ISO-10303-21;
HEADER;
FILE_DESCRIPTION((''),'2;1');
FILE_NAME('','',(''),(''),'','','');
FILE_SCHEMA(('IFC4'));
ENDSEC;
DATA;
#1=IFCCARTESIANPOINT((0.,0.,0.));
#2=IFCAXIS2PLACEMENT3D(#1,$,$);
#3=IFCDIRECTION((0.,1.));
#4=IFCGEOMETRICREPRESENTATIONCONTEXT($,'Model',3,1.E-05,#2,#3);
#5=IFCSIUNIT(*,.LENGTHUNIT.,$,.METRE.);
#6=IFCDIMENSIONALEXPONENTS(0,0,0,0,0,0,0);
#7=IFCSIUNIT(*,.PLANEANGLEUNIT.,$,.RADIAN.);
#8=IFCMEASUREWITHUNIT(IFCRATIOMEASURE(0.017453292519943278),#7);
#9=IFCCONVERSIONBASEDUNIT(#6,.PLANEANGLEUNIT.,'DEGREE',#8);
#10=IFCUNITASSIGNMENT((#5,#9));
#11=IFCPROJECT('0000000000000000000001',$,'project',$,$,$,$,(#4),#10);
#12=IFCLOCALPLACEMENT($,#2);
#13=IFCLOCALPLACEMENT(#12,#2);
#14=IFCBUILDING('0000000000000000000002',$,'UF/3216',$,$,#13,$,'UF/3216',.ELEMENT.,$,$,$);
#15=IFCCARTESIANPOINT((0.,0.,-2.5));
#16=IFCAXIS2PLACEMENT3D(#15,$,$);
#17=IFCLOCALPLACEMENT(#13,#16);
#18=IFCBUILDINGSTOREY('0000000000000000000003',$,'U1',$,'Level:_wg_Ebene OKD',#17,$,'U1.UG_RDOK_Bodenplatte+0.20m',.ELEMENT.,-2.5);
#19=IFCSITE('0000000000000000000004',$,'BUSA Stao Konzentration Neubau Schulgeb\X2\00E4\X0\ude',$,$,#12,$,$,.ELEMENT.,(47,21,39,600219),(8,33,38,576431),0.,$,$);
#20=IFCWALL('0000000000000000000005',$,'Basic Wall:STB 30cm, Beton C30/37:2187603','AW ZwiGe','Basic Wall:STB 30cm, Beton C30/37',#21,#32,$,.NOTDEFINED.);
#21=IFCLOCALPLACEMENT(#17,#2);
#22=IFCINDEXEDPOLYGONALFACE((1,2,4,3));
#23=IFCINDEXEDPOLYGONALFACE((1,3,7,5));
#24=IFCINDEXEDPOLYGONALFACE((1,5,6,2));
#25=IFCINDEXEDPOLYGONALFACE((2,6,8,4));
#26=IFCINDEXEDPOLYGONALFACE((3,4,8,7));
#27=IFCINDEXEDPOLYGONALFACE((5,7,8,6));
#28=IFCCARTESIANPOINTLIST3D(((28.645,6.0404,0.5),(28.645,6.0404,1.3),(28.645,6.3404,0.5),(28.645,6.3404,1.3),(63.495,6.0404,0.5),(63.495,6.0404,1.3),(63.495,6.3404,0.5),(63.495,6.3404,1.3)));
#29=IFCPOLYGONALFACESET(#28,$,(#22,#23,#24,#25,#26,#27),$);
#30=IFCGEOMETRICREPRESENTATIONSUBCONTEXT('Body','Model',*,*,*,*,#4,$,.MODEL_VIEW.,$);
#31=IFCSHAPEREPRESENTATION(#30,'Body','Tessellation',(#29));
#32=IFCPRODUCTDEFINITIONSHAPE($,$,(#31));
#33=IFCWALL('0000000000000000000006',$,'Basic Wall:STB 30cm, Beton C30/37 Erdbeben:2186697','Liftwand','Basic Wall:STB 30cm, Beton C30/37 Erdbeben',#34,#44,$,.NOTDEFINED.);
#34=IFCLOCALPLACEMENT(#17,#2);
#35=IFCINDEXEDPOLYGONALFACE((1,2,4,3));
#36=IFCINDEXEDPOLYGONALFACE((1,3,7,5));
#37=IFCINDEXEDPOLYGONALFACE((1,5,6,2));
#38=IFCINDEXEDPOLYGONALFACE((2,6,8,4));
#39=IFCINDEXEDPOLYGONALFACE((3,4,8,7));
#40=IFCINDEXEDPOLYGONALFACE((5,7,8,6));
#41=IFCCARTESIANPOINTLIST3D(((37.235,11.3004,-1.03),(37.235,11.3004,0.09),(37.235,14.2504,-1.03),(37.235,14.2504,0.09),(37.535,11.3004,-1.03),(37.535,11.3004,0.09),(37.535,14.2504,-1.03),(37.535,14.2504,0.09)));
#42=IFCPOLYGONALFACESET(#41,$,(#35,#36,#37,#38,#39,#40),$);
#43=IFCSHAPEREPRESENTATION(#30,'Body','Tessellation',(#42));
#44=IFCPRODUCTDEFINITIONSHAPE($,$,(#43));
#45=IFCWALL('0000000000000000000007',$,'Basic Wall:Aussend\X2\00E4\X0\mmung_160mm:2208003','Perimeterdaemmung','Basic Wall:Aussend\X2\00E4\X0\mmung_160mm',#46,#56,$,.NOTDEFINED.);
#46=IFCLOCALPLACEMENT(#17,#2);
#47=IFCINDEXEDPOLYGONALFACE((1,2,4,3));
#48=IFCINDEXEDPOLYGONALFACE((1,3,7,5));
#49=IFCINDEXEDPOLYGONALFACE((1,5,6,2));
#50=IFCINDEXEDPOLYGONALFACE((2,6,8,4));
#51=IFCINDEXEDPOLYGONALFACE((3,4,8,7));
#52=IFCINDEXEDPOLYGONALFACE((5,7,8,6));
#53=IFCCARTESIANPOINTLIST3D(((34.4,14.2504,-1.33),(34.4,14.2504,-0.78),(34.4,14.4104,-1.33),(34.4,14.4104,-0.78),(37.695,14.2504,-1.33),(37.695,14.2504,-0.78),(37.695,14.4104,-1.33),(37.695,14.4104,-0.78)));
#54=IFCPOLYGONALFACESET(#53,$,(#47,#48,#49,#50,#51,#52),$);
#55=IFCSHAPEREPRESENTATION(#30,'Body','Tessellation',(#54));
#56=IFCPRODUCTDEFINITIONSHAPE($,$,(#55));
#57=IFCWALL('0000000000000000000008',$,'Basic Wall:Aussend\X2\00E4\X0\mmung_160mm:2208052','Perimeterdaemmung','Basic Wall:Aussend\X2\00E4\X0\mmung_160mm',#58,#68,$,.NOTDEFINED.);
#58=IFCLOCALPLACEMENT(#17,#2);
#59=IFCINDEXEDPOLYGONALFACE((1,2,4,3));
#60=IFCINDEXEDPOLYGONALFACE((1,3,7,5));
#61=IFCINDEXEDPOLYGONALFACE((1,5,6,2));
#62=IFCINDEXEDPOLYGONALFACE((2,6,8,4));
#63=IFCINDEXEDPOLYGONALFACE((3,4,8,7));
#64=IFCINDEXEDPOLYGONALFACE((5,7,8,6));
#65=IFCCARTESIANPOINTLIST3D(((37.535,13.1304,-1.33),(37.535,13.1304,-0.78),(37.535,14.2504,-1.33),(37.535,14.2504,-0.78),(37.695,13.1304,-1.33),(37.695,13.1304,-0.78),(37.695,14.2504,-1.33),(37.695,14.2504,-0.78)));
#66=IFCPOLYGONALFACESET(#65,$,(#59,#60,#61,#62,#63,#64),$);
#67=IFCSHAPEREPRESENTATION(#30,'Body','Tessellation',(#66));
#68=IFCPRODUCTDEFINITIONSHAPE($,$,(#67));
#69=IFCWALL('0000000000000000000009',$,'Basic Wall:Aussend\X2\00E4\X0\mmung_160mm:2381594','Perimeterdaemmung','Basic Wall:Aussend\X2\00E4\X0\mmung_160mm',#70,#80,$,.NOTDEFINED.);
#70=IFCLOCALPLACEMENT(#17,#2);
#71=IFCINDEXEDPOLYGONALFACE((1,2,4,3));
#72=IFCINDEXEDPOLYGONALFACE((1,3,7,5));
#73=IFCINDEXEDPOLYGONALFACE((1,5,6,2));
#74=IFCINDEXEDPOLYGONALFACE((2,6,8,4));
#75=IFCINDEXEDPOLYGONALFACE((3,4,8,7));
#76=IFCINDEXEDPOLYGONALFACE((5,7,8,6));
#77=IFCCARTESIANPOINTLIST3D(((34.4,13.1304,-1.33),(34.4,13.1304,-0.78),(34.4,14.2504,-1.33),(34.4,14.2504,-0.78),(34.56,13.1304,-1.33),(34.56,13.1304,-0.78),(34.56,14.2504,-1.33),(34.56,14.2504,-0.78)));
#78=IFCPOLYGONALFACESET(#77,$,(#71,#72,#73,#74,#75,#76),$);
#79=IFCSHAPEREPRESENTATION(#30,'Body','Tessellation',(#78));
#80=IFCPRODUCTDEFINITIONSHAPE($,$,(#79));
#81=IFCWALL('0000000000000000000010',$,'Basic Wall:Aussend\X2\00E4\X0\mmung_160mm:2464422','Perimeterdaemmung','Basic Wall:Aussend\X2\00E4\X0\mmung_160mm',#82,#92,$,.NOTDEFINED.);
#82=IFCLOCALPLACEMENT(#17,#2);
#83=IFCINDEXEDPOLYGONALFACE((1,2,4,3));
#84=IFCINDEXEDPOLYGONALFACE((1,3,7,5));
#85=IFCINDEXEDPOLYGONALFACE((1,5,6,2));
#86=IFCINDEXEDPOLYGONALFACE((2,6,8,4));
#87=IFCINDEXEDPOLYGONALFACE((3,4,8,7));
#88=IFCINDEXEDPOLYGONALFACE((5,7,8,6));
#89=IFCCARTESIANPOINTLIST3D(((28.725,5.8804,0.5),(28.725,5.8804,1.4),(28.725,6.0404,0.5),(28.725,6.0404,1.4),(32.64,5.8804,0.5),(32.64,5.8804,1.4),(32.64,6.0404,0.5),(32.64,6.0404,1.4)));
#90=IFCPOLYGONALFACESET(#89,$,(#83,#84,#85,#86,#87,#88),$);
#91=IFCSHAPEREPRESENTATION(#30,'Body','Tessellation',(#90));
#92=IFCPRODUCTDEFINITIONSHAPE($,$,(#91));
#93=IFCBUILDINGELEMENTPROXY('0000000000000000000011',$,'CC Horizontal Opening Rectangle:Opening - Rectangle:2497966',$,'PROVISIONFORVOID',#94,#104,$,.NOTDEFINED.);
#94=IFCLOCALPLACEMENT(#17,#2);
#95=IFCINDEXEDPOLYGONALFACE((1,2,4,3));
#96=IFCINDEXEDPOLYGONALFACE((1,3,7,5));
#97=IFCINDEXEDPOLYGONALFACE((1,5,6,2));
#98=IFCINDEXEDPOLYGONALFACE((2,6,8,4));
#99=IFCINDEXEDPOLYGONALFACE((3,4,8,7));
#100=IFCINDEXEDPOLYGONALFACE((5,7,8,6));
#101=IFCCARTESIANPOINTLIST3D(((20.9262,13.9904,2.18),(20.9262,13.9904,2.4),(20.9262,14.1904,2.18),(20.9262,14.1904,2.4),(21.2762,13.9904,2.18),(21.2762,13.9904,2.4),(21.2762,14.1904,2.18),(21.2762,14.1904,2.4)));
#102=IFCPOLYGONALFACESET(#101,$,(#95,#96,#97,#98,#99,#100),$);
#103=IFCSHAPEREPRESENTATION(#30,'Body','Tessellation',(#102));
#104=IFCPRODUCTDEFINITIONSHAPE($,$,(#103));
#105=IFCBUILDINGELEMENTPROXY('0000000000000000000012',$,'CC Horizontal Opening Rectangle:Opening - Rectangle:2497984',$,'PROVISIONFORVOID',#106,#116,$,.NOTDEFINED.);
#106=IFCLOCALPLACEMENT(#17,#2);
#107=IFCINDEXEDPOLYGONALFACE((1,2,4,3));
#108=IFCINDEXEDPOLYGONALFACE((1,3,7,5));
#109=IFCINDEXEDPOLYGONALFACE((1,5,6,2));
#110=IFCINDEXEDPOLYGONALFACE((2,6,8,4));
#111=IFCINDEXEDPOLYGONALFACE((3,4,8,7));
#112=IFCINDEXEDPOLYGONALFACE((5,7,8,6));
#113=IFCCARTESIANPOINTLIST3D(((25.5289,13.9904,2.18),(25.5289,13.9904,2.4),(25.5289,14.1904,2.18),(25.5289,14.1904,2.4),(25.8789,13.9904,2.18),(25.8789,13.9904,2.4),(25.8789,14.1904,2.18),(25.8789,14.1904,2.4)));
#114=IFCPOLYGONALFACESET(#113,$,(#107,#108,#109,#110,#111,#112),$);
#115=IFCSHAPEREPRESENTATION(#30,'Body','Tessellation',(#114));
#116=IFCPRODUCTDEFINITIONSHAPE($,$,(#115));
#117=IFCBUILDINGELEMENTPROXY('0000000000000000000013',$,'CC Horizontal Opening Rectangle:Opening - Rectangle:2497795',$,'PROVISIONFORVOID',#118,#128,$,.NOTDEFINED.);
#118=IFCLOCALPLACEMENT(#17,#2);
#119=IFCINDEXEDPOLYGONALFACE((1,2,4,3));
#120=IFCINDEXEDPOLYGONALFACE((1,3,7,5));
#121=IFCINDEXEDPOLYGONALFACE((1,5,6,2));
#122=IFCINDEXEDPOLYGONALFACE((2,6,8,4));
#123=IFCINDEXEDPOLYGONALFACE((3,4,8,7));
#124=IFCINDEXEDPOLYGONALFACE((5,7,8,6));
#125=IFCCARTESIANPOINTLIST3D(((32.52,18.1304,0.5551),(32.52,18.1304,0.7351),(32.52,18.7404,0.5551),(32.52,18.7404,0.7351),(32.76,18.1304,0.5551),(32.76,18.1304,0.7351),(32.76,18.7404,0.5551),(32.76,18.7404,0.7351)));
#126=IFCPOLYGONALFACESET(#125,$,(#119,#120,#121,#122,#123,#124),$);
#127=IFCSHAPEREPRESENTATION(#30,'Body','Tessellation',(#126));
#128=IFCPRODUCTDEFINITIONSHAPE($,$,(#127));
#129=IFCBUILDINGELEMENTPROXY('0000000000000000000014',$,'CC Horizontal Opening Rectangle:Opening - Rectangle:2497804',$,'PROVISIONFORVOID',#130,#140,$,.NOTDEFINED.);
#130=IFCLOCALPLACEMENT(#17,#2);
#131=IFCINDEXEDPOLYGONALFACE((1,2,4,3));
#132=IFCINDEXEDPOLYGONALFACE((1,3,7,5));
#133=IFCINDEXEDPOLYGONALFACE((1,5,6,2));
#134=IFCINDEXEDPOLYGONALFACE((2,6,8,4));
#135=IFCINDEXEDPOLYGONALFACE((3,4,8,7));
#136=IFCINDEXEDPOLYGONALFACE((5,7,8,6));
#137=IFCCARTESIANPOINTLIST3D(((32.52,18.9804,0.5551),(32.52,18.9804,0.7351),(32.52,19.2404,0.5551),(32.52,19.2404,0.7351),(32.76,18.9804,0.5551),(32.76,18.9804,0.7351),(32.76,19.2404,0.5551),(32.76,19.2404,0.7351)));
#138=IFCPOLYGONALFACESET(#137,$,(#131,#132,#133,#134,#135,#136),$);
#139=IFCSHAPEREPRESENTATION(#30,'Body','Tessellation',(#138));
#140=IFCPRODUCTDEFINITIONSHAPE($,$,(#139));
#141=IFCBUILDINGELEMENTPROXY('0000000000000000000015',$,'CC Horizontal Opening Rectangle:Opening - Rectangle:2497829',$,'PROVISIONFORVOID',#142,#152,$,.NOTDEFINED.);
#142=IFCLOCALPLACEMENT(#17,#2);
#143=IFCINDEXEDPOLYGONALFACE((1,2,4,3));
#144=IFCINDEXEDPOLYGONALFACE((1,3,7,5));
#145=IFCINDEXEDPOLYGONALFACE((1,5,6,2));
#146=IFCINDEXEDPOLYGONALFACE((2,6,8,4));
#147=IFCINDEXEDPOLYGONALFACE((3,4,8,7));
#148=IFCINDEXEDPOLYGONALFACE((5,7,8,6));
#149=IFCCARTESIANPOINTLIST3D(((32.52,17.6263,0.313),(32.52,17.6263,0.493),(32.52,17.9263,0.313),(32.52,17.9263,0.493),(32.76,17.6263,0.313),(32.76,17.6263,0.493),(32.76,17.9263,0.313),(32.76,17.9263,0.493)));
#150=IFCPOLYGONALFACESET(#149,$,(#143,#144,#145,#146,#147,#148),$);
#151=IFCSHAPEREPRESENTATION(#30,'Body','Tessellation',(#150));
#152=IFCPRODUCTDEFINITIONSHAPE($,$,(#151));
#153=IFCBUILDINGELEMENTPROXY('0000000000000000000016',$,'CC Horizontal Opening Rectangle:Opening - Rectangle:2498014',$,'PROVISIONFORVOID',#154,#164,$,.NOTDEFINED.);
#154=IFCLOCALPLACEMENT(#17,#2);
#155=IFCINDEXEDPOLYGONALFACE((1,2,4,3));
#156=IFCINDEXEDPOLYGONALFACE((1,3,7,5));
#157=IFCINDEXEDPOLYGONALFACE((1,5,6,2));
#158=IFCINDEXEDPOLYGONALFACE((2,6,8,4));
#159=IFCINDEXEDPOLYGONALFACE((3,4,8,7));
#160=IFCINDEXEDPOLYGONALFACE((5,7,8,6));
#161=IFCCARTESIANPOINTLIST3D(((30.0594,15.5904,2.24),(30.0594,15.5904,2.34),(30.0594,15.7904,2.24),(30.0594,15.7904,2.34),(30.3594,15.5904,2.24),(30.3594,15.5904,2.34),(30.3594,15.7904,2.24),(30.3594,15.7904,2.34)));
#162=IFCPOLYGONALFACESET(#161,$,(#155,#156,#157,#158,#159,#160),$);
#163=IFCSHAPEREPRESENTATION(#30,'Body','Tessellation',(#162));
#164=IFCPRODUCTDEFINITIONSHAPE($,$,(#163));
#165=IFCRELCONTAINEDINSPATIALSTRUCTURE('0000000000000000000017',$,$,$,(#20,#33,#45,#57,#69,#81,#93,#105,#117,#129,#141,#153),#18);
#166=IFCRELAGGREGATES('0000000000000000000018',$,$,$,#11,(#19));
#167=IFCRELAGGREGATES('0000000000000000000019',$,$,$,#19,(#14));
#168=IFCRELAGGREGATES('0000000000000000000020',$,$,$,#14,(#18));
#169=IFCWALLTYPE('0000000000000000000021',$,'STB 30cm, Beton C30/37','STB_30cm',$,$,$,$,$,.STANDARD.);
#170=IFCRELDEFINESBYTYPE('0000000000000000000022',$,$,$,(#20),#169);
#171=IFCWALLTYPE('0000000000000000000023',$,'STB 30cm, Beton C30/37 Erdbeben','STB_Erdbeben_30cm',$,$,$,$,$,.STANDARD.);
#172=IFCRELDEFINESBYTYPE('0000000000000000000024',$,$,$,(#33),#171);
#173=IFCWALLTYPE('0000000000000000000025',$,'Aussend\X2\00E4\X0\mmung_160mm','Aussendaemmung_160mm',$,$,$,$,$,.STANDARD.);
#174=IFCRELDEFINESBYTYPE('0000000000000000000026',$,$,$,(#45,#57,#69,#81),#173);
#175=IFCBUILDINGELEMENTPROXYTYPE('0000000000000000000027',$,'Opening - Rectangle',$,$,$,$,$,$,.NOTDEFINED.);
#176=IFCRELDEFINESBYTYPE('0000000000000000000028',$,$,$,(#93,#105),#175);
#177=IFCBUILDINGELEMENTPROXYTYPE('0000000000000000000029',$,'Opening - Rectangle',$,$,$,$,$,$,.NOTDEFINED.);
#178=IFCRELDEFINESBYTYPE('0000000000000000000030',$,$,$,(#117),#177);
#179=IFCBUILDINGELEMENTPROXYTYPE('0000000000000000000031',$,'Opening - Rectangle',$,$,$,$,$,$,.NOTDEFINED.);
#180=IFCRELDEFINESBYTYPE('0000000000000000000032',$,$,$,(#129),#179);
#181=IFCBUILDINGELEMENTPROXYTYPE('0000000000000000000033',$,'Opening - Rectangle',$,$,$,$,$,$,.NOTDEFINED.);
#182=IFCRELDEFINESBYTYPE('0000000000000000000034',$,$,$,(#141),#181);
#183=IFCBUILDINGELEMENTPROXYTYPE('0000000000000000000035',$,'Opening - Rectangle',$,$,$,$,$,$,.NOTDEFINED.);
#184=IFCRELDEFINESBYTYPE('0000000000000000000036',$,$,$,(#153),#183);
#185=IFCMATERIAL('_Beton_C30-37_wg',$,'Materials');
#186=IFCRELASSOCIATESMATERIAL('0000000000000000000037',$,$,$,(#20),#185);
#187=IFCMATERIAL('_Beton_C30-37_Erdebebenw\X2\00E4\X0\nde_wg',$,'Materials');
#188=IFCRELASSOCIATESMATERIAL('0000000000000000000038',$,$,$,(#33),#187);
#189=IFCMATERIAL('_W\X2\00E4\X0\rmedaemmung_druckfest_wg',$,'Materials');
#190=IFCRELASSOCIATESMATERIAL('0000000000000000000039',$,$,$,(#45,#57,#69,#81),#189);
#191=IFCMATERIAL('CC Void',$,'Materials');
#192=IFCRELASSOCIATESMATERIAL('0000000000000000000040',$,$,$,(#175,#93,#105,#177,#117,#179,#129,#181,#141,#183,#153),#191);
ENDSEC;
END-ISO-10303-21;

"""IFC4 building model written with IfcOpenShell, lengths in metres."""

from ifc_helpers import new_model, entity, si_unit, converted_unit, direction, frame, origin, place, context, subcontext, project, spatial, indexed_curve, outline, extrude, source, transform, mapped, material, type_object, type_shapes, element, save


model = new_model("IFC4")

# Units and contexts
model_context = context("Model", 3, precision=1e-05, world=origin(), true_north=direction((0.0, 1.0)))
body_context = subcontext(model_context, "Body", "Model", "MODEL_VIEW")
ifc_project = project(units=[si_unit("LENGTHUNIT", "METRE"), converted_unit("PLANEANGLEUNIT", "DEGREE", entity("IfcRatioMeasure", 0.017453292519943278), si_unit("PLANEANGLEUNIT", "RADIAN"), dimensions=[0, 0, 0, 0, 0, 0, 0])], contexts=[model_context])

# Site, building, storey
site_placement = place(None, origin())
site = spatial("IfcSite", under=ifc_project, at=site_placement, Name="BUSA Stao Konzentration Neubau Schulgebäude", CompositionType="ELEMENT", RefLatitude=(47, 21, 39, 600219), RefLongitude=(8, 33, 38, 576431), RefElevation=0.0)
building_placement = place(site_placement, origin())
building = spatial("IfcBuilding", under=site, at=building_placement, Name="UF/3216", LongName="UF/3216", CompositionType="ELEMENT")
storey_placement = place(building_placement, frame((0.0, 0.0, -2.5)))
storey = spatial("IfcBuildingStorey", under=building, at=storey_placement, Name="U1", ObjectType="Level:_wg_Ebene OKD", LongName="U1.UG_RDOK_Bodenplatte+0.20m", CompositionType="ELEMENT", Elevation=-2.5)

# Walls
ifc_material_1 = material(Name="_Beton_C30-37_wg", Category="Materials")
wall_type_1 = type_object("IfcWallType", Name="STB 30cm, Beton C30/37", Description="STB_30cm", PredefinedType="STANDARD")
wall_1_placement = place(storey_placement, frame((28.645, 6.1904, 0.5)))
element("IfcWall", 1, at=wall_1_placement, inside=storey, type_object=wall_type_1, material=ifc_material_1, Name="Basic Wall:STB 30cm, Beton C30/37:2187603", Description="AW ZwiGe", ObjectType="Basic Wall:STB 30cm, Beton C30/37", PredefinedType="NOTDEFINED", context=body_context, shape_type="SweptSolid", body=[
    extrude(outline(indexed_curve([(34.85, 0.15), (0.0, 0.15), (0.0, -0.15), (34.85, -0.15), (34.85, 0.15)], self_intersect=False)), origin(), (0.0, 0.0, 1.0), 0.8),
])
ifc_material_2 = material(Name="_Beton_C30-37_Erdebebenwände_wg", Category="Materials")
wall_type_2 = type_object("IfcWallType", Name="STB 30cm, Beton C30/37 Erdbeben", Description="STB_Erdbeben_30cm", PredefinedType="STANDARD")
wall_2_placement = place(storey_placement, frame((37.385, 14.2504, -1.03), z_axis=(0.0, 0.0, 1.0), x_axis=(0.0, -1.0, 0.0)))
element("IfcWall", 2, at=wall_2_placement, inside=storey, type_object=wall_type_2, material=ifc_material_2, Name="Basic Wall:STB 30cm, Beton C30/37 Erdbeben:2186697", Description="Liftwand", ObjectType="Basic Wall:STB 30cm, Beton C30/37 Erdbeben", PredefinedType="NOTDEFINED", context=body_context, shape_type="SweptSolid", body=[
    extrude(outline(indexed_curve([(2.95, 0.15), (0.0, 0.15), (0.0, -0.15), (2.95, -0.15), (2.95, 0.15)], self_intersect=False)), origin(), (0.0, 0.0, 1.0), 1.12),
])
ifc_material_3 = material(Name="_Wärmedaemmung_druckfest_wg", Category="Materials")
wall_type_3 = type_object("IfcWallType", Name="Aussendämmung_160mm", Description="Aussendaemmung_160mm", PredefinedType="STANDARD")
wall_3_placement = place(storey_placement, frame((34.4, 14.3304, -1.33)))
element("IfcWall", 3, at=wall_3_placement, inside=storey, type_object=wall_type_3, material=ifc_material_3, Name="Basic Wall:Aussendämmung_160mm:2208003", Description="Perimeterdaemmung", ObjectType="Basic Wall:Aussendämmung_160mm", PredefinedType="NOTDEFINED", context=body_context, shape_type="SweptSolid", body=[
    extrude(outline(indexed_curve([(3.295, 0.08), (0.0, 0.08), (0.0, -0.08), (3.295, -0.08), (3.295, 0.08)], self_intersect=False)), origin(), (0.0, 0.0, 1.0), 0.55),
])
for number, where, z_axis, x_axis, name in (
    (4, (37.615, 14.2504, -1.33), (0.0, 0.0, 1.0), (0.0, -1.0, 0.0), "Basic Wall:Aussendämmung_160mm:2208052"),
    (5, (34.48, 13.1304, -1.33), (0.0, 0.0, 1.0), (0.0, 1.0, 0.0), "Basic Wall:Aussendämmung_160mm:2381594"),
):
    element("IfcWall", number, at=place(storey_placement, frame(where, z_axis=z_axis, x_axis=x_axis)), inside=storey, type_object=wall_type_3, material=ifc_material_3, Name=name, Description="Perimeterdaemmung", ObjectType="Basic Wall:Aussendämmung_160mm", PredefinedType="NOTDEFINED", context=body_context, shape_type="SweptSolid", body=[
        extrude(outline(indexed_curve([(1.12, 0.08), (0.0, 0.08), (0.0, -0.08), (1.12, -0.08), (1.12, 0.08)], self_intersect=False)), origin(), (0.0, 0.0, 1.0), 0.55),
    ])
wall_4_placement = place(storey_placement, frame((32.64, 5.9604, 0.5), z_axis=(0.0, 0.0, 1.0), x_axis=(-1.0, 0.0, 0.0)))
element("IfcWall", 6, at=wall_4_placement, inside=storey, type_object=wall_type_3, material=ifc_material_3, Name="Basic Wall:Aussendämmung_160mm:2464422", Description="Perimeterdaemmung", ObjectType="Basic Wall:Aussendämmung_160mm", PredefinedType="NOTDEFINED", context=body_context, shape_type="SweptSolid", body=[
    extrude(outline(indexed_curve([(3.915, 0.08), (0.0, 0.08), (0.0, -0.08), (3.915, -0.08), (3.915, 0.08)], self_intersect=False)), origin(), (0.0, 0.0, 1.0), 0.9),
])

# Building element proxies
ifc_material_4 = material(Name="CC Void", Category="Materials")
building_element_proxy_type_1 = type_object("IfcBuildingElementProxyType", Name="Opening - Rectangle", PredefinedType="NOTDEFINED", material=ifc_material_4)
shared_shape_1 = source(origin(), body_context, "Body", "SweptSolid", [
    extrude(outline(indexed_curve([(-0.1, -0.175), (0.1, -0.175), (0.1, 0.175), (-0.1, 0.175), (-0.1, -0.175)], self_intersect=False)), frame((0.0, 0.0, -0.32), z_axis=(0.0, 0.0, 1.0), x_axis=(0.0, -1.0, 0.0)), (0.0, 0.0, 1.0), 0.22),
])
type_shapes(building_element_proxy_type_1, [shared_shape_1])
for number, where, name in (
    (7, (21.1012, 14.0904, 2.5), "CC Horizontal Opening Rectangle:Opening - Rectangle:2497966"),
    (8, (25.7039, 14.0904, 2.5), "CC Horizontal Opening Rectangle:Opening - Rectangle:2497984"),
):
    element("IfcBuildingElementProxy", number, at=place(storey_placement, frame(where)), inside=storey, type_object=building_element_proxy_type_1, material=ifc_material_4, Name=name, ObjectType="PROVISIONFORVOID", PredefinedType="NOTDEFINED", context=body_context, shape_type="MappedRepresentation", body=[
        mapped(shared_shape_1, transform((0.0, 0.0, 0.0), scale=1.0)),
    ])
building_element_proxy_type_2 = type_object("IfcBuildingElementProxyType", Name="Opening - Rectangle", PredefinedType="NOTDEFINED", material=ifc_material_4)
shared_shape_2 = source(origin(), body_context, "Body", "SweptSolid", [
    extrude(outline(indexed_curve([(-0.12, -0.305), (0.12, -0.305), (0.12, 0.305), (-0.12, 0.305), (-0.12, -0.305)], self_intersect=False)), frame((0.0, 0.0, -1.9449), z_axis=(0.0, 0.0, 1.0), x_axis=(0.0, -1.0, 0.0)), (0.0, 0.0, 1.0), 0.18),
])
type_shapes(building_element_proxy_type_2, [shared_shape_2])
proxy_1_placement = place(storey_placement, frame((32.64, 18.4354, 2.5), z_axis=(0.0, 0.0, 1.0), x_axis=(0.0, 1.0, 0.0)))
element("IfcBuildingElementProxy", 9, at=proxy_1_placement, inside=storey, type_object=building_element_proxy_type_2, material=ifc_material_4, Name="CC Horizontal Opening Rectangle:Opening - Rectangle:2497795", ObjectType="PROVISIONFORVOID", PredefinedType="NOTDEFINED", context=body_context, shape_type="MappedRepresentation", body=[
    mapped(shared_shape_2, transform((0.0, 0.0, 0.0), scale=1.0)),
])
building_element_proxy_type_3 = type_object("IfcBuildingElementProxyType", Name="Opening - Rectangle", PredefinedType="NOTDEFINED", material=ifc_material_4)
shared_shape_3 = source(origin(), body_context, "Body", "SweptSolid", [
    extrude(outline(indexed_curve([(-0.12, -0.13), (0.12, -0.13), (0.12, 0.13), (-0.12, 0.13), (-0.12, -0.13)], self_intersect=False)), frame((0.0, 0.0, -1.9449), z_axis=(0.0, 0.0, 1.0), x_axis=(0.0, -1.0, 0.0)), (0.0, 0.0, 1.0), 0.18),
])
type_shapes(building_element_proxy_type_3, [shared_shape_3])
proxy_2_placement = place(storey_placement, frame((32.64, 19.1104, 2.5), z_axis=(0.0, 0.0, 1.0), x_axis=(0.0, 1.0, 0.0)))
element("IfcBuildingElementProxy", 10, at=proxy_2_placement, inside=storey, type_object=building_element_proxy_type_3, material=ifc_material_4, Name="CC Horizontal Opening Rectangle:Opening - Rectangle:2497804", ObjectType="PROVISIONFORVOID", PredefinedType="NOTDEFINED", context=body_context, shape_type="MappedRepresentation", body=[
    mapped(shared_shape_3, transform((0.0, 0.0, 0.0), scale=1.0)),
])
building_element_proxy_type_4 = type_object("IfcBuildingElementProxyType", Name="Opening - Rectangle", PredefinedType="NOTDEFINED", material=ifc_material_4)
shared_shape_4 = source(origin(), body_context, "Body", "SweptSolid", [
    extrude(outline(indexed_curve([(-0.12, -0.15), (0.12, -0.15), (0.12, 0.15), (-0.12, 0.15), (-0.12, -0.15)], self_intersect=False)), frame((0.0, 0.0, -2.187), z_axis=(0.0, 0.0, 1.0), x_axis=(0.0, -1.0, 0.0)), (0.0, 0.0, 1.0), 0.18),
])
type_shapes(building_element_proxy_type_4, [shared_shape_4])
proxy_3_placement = place(storey_placement, frame((32.64, 17.7763, 2.5), z_axis=(0.0, 0.0, 1.0), x_axis=(0.0, 1.0, 0.0)))
element("IfcBuildingElementProxy", 11, at=proxy_3_placement, inside=storey, type_object=building_element_proxy_type_4, material=ifc_material_4, Name="CC Horizontal Opening Rectangle:Opening - Rectangle:2497829", ObjectType="PROVISIONFORVOID", PredefinedType="NOTDEFINED", context=body_context, shape_type="MappedRepresentation", body=[
    mapped(shared_shape_4, transform((0.0, 0.0, 0.0), scale=1.0)),
])
building_element_proxy_type_5 = type_object("IfcBuildingElementProxyType", Name="Opening - Rectangle", PredefinedType="NOTDEFINED", material=ifc_material_4)
shared_shape_5 = source(origin(), body_context, "Body", "SweptSolid", [
    extrude(outline(indexed_curve([(-0.1, -0.15), (0.1, -0.15), (0.1, 0.15), (-0.1, 0.15), (-0.1, -0.15)], self_intersect=False)), frame((0.0, 0.0, -0.26), z_axis=(0.0, 0.0, 1.0), x_axis=(0.0, -1.0, 0.0)), (0.0, 0.0, 1.0), 0.1),
])
type_shapes(building_element_proxy_type_5, [shared_shape_5])
proxy_4_placement = place(storey_placement, frame((30.2094, 15.6904, 2.5)))
element("IfcBuildingElementProxy", 12, at=proxy_4_placement, inside=storey, type_object=building_element_proxy_type_5, material=ifc_material_4, Name="CC Horizontal Opening Rectangle:Opening - Rectangle:2498014", ObjectType="PROVISIONFORVOID", PredefinedType="NOTDEFINED", context=body_context, shape_type="MappedRepresentation", body=[
    mapped(shared_shape_5, transform((0.0, 0.0, 0.0), scale=1.0)),
])

save(model, "model.ifc")
